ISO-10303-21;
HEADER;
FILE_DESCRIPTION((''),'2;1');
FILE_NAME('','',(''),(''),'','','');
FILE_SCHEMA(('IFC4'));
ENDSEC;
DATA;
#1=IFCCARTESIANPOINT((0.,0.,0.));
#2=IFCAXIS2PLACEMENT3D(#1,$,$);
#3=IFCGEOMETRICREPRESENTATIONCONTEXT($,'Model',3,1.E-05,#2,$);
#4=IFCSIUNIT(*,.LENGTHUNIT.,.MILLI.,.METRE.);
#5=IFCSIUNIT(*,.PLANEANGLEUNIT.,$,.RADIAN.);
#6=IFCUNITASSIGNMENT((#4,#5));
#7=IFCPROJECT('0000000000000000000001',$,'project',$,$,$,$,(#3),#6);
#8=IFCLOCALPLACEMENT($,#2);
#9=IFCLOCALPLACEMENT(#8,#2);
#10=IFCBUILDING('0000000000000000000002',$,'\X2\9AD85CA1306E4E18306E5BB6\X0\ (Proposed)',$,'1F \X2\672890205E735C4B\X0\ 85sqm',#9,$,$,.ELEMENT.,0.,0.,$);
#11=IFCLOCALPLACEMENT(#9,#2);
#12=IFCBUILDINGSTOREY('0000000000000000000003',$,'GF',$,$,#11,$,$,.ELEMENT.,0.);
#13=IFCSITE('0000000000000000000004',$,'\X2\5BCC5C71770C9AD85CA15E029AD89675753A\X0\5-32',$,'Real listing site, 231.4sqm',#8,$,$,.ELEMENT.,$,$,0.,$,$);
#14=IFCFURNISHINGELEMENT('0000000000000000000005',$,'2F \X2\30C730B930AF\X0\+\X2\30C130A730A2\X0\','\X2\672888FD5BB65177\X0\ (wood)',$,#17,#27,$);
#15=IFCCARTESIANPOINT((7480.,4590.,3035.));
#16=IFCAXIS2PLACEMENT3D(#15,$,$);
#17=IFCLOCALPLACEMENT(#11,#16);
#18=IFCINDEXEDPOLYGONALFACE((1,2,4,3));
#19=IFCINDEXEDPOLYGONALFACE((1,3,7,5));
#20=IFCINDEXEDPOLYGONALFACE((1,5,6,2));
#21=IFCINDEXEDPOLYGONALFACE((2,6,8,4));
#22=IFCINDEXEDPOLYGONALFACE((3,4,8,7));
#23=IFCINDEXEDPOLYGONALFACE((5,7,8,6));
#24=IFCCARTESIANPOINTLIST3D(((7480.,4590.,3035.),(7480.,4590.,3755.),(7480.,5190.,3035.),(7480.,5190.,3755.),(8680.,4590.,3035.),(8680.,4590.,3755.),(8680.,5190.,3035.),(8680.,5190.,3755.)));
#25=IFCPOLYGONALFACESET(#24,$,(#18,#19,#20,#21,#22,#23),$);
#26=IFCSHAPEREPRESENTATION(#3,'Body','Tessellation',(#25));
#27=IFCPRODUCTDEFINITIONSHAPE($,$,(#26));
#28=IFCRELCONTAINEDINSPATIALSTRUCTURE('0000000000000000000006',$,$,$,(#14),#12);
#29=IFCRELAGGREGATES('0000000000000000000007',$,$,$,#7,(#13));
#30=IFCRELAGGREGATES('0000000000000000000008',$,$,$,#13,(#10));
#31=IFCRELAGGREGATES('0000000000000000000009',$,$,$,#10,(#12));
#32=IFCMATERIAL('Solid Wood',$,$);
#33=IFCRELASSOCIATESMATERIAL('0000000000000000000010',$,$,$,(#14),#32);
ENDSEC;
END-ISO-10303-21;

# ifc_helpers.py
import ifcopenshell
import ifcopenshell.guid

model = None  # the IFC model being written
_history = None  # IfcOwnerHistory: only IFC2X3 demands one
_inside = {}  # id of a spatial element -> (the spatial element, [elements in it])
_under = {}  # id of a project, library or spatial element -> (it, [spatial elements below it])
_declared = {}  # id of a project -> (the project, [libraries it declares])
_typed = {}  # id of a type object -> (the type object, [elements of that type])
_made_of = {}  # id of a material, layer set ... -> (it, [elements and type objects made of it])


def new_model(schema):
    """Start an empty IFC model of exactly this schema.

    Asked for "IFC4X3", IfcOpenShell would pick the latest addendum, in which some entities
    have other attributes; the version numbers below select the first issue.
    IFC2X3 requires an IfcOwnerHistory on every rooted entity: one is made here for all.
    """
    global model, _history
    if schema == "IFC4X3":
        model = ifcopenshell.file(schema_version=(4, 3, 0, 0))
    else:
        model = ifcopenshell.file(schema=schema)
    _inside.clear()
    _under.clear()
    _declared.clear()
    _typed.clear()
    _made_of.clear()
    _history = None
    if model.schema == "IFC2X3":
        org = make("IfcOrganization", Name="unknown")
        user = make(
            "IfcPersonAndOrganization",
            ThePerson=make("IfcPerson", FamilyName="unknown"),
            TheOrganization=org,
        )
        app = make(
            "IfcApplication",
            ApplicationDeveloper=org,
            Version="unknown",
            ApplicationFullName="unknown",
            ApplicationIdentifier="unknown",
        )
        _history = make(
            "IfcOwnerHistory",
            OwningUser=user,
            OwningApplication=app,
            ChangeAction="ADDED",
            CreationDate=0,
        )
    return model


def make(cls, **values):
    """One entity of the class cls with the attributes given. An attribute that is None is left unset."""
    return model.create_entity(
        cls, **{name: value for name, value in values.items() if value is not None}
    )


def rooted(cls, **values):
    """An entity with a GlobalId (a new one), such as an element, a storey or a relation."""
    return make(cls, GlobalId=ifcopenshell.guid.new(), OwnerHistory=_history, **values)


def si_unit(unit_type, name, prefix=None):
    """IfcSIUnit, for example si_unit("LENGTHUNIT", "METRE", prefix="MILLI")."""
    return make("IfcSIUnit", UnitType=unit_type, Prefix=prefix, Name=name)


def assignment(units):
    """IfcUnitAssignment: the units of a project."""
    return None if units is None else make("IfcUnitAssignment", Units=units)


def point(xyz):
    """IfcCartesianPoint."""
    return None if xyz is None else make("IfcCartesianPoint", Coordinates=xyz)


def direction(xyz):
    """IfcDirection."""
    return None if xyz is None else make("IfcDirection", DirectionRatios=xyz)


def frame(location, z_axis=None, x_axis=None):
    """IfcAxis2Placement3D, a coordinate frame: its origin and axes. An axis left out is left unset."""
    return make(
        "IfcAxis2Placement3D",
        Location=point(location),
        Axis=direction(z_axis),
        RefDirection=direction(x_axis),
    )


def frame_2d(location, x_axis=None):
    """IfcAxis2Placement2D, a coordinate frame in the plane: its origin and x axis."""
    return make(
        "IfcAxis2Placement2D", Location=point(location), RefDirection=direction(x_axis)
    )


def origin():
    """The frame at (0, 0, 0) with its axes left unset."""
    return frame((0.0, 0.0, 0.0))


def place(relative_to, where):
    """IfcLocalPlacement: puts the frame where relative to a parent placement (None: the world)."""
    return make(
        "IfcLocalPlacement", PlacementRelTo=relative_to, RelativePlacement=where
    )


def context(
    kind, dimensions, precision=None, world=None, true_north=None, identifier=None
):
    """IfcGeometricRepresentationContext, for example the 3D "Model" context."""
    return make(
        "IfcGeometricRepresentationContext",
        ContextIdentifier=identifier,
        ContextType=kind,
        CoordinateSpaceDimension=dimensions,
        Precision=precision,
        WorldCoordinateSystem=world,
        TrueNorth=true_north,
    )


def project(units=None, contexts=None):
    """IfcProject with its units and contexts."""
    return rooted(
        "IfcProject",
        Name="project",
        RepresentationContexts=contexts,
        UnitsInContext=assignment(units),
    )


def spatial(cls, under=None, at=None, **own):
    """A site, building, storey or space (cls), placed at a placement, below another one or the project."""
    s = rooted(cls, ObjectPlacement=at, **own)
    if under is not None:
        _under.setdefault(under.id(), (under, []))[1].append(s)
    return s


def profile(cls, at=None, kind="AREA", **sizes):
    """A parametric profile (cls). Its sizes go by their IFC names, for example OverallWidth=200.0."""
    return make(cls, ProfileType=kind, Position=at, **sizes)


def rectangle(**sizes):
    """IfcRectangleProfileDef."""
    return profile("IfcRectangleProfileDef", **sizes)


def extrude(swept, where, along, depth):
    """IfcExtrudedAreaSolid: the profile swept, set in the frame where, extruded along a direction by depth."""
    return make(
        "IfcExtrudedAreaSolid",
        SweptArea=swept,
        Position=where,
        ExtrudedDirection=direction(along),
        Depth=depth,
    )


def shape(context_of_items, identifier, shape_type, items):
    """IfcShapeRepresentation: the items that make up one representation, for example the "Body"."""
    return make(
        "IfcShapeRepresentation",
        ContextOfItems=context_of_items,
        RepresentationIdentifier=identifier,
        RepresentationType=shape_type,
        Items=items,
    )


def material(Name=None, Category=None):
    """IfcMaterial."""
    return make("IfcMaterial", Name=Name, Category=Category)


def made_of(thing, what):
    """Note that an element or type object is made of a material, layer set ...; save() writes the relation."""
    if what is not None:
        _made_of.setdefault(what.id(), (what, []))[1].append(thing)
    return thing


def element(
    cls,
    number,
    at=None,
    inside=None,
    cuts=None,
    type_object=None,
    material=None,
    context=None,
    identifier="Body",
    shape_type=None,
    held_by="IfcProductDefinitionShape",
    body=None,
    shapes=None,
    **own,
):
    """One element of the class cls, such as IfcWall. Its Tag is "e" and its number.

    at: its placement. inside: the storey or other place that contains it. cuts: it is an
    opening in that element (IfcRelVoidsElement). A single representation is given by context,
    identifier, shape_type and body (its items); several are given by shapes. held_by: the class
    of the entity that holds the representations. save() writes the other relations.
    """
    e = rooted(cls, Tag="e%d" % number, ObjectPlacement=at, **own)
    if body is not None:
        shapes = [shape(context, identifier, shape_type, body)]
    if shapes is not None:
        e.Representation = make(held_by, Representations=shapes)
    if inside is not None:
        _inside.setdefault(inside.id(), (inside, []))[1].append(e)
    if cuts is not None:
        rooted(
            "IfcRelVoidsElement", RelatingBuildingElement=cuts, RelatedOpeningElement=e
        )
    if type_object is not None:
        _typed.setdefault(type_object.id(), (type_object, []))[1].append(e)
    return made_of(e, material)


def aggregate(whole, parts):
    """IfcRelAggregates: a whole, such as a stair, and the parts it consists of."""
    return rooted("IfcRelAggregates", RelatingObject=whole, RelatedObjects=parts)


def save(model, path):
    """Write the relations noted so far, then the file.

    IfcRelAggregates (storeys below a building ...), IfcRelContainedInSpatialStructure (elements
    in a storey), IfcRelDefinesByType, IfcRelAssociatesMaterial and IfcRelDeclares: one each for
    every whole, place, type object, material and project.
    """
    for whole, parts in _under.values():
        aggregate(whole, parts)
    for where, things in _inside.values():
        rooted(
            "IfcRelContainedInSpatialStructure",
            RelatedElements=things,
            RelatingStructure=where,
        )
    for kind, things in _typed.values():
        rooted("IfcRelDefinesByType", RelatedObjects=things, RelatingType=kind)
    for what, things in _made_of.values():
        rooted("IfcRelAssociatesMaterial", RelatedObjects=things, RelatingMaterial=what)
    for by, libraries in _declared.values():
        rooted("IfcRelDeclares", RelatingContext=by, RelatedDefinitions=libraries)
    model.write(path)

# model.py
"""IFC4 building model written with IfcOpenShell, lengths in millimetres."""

from ifc_helpers import new_model, si_unit, frame, frame_2d, origin, place, context, project, spatial, rectangle, extrude, material, element, save


model = new_model("IFC4")

# Units and contexts
model_context = context("Model", 3, precision=1e-05, world=origin())
ifc_project = project(units=[si_unit("LENGTHUNIT", "METRE", prefix="MILLI"), si_unit("PLANEANGLEUNIT", "RADIAN")], contexts=[model_context])

# Site, building, storey
site_placement = place(None, origin())
site = spatial("IfcSite", under=ifc_project, at=site_placement, Name="富山県高岡市高陵町5-32", ObjectType="Real listing site, 231.4sqm", CompositionType="ELEMENT", RefElevation=0.0)
building_placement = place(site_placement, origin())
building = spatial("IfcBuilding", under=site, at=building_placement, Name="高岡の丘の家 (Proposed)", ObjectType="1F 木造平屋 85sqm", CompositionType="ELEMENT", ElevationOfRefHeight=0.0, ElevationOfTerrain=0.0)
storey_placement = place(building_placement, origin())
storey = spatial("IfcBuildingStorey", under=building, at=storey_placement, Name="GF", CompositionType="ELEMENT", Elevation=0.0)

# Shared definitions
ifc_material_1 = material(Name="Solid Wood")

# Furnishing element
furnishing_1_placement = place(storey_placement, frame((7480.0, 4590.0, 3035.0)))
element("IfcFurnishingElement", 1, at=furnishing_1_placement, inside=storey, material=ifc_material_1, Name="2F デスク+チェア", Description="木製家具 (wood)", context=model_context, shape_type="SweptSolid", body=[
    extrude(rectangle(XDim=1200.0, YDim=600.0, at=frame_2d((600.0, 300.0))), frame((7480.0, 4590.0, 3035.0)), (0.0, 0.0, 1.0), 720.0),
])

save(model, "model.ifc")
